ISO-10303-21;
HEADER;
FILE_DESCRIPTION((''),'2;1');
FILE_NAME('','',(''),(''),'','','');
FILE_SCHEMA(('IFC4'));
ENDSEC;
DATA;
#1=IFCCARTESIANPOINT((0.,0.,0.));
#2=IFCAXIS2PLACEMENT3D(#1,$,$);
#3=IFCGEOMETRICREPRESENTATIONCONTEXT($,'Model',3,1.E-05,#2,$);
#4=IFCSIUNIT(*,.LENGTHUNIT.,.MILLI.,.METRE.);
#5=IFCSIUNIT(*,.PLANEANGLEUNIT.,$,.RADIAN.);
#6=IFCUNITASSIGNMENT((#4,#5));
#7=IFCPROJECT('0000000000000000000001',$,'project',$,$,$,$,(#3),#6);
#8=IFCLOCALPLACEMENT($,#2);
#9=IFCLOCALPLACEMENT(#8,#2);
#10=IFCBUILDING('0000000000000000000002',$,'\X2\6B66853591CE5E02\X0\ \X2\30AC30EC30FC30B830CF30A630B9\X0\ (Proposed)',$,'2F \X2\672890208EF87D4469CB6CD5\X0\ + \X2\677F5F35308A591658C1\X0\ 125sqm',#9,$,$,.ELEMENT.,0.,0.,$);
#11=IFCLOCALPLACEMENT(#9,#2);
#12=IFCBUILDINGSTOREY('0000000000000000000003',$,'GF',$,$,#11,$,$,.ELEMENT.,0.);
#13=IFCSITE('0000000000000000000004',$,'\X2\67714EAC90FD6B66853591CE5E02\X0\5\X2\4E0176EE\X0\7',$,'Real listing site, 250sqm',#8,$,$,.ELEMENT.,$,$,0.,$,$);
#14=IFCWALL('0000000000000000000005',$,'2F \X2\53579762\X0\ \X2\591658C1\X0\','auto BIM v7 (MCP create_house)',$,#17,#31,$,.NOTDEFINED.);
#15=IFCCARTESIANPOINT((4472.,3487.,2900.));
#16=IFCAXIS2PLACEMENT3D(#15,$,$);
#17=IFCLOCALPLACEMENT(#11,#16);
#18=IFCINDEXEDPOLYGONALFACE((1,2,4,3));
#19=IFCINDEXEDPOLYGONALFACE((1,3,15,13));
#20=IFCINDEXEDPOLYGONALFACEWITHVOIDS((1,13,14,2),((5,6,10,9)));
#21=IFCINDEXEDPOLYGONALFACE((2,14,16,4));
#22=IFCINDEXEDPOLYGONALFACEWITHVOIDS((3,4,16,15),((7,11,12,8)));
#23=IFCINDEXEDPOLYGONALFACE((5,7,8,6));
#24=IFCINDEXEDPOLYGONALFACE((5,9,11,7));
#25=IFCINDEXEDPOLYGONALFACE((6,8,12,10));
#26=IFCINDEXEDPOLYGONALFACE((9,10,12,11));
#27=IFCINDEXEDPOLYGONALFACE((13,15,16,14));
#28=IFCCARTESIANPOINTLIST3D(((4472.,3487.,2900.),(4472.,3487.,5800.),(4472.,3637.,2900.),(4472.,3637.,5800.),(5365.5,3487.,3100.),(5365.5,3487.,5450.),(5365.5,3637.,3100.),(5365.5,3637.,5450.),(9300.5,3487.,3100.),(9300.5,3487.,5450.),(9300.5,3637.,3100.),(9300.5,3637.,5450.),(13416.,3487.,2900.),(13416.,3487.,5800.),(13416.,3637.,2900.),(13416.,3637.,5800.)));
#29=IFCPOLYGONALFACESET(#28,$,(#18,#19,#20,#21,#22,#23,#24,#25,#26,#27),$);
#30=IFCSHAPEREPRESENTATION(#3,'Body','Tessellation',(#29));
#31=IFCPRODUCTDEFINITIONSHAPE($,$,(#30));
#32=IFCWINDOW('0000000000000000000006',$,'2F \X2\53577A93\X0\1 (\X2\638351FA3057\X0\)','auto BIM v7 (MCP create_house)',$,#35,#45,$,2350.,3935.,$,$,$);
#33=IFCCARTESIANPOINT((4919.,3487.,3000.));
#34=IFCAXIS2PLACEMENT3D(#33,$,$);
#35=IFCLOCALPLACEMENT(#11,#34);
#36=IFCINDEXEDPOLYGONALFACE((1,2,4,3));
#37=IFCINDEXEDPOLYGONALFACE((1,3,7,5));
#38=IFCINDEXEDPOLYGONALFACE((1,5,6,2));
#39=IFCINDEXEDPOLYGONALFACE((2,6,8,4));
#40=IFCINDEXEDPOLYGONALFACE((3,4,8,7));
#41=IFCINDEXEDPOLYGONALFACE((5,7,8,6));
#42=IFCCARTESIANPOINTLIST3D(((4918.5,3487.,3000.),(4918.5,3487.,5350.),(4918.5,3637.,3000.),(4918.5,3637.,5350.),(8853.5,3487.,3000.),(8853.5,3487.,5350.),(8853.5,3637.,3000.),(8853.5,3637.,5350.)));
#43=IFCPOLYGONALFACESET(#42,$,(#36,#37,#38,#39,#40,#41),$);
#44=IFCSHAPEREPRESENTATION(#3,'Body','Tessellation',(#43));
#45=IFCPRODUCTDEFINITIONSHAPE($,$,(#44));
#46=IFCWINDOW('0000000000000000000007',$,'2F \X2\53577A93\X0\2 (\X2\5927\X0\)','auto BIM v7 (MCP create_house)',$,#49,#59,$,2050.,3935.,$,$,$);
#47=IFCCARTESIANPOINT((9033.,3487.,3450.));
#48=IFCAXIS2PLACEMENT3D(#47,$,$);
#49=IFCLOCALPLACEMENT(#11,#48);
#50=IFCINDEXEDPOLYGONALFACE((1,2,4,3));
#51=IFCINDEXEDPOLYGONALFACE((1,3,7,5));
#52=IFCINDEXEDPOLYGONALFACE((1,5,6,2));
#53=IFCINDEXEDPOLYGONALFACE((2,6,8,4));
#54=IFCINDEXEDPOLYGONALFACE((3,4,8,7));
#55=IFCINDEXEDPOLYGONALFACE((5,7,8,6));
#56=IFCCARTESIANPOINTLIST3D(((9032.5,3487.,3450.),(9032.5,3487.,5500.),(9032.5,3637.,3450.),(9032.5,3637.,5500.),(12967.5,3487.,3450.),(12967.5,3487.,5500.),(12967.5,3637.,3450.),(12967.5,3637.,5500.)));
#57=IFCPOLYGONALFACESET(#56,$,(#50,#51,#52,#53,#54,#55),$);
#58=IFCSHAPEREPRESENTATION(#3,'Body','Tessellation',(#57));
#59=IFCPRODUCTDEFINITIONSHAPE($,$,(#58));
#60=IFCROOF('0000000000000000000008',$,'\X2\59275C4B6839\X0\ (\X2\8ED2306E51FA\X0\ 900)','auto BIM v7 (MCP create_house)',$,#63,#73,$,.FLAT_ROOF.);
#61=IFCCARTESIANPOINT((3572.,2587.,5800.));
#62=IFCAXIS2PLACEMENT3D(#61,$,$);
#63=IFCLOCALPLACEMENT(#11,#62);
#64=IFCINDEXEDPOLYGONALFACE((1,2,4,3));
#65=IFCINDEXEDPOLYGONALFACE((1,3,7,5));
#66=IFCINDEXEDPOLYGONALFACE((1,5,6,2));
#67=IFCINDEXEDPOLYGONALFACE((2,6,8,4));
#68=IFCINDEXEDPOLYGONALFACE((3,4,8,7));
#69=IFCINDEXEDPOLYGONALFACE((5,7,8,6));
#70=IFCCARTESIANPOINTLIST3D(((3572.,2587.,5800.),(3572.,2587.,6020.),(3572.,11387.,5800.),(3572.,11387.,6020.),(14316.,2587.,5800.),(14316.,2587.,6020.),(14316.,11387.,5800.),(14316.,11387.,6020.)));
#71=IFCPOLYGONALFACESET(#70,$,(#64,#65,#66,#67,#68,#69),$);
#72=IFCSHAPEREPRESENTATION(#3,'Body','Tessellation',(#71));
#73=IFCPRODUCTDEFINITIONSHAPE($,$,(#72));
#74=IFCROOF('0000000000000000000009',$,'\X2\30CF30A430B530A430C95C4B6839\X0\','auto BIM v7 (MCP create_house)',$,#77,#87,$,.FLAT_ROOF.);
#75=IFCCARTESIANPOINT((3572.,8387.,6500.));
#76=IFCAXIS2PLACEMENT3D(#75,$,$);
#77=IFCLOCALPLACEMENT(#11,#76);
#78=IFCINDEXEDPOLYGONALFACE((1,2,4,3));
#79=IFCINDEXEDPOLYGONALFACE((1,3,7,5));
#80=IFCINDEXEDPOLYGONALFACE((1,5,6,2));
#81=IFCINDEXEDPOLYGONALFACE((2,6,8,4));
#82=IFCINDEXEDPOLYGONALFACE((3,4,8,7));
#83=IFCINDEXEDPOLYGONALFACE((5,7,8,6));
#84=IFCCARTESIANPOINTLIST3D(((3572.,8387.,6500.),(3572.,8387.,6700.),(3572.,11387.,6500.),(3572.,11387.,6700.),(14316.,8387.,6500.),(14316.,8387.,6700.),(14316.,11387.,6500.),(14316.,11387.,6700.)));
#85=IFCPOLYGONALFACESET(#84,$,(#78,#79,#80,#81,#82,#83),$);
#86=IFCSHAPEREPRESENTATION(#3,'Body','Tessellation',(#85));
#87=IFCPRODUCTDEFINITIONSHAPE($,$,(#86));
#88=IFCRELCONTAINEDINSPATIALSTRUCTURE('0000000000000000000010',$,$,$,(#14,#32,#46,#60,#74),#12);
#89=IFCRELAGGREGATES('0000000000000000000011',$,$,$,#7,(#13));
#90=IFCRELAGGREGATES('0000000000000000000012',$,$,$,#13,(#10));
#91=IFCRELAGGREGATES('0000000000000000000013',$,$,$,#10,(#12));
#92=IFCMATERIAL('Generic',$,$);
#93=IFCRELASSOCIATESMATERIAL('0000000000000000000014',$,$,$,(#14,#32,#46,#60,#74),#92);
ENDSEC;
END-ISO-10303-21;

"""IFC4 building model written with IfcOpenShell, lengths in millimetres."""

from ifc_helpers import new_model, si_unit, frame, frame_2d, origin, place, context, project, spatial, rectangle, extrude, material, element, fill, save


model = new_model("IFC4")

# Units and contexts
model_context = context("Model", 3, precision=1e-05, world=origin())
ifc_project = project(units=[si_unit("LENGTHUNIT", "METRE", prefix="MILLI"), si_unit("PLANEANGLEUNIT", "RADIAN")], contexts=[model_context])

# Site, building, storey
site_placement = place(None, origin())
site = spatial("IfcSite", under=ifc_project, at=site_placement, Name="東京都武蔵野市5丁目7", ObjectType="Real listing site, 250sqm", CompositionType="ELEMENT", RefElevation=0.0)
building_placement = place(site_placement, origin())
building = spatial("IfcBuilding", under=site, at=building_placement, Name="武蔵野市 ガレージハウス (Proposed)", ObjectType="2F 木造軸組構法 + 板張り外壁 125sqm", CompositionType="ELEMENT", ElevationOfRefHeight=0.0, ElevationOfTerrain=0.0)
storey_placement = place(building_placement, origin())
storey = spatial("IfcBuildingStorey", under=building, at=storey_placement, Name="GF", CompositionType="ELEMENT", Elevation=0.0)

# Shared definitions
ifc_material = material(Name="Generic")

# Wall, openings, windows
wall_1_placement = place(storey_placement, frame((4472.0, 3487.0, 2900.0)))
wall_1 = element("IfcWall", 1, at=wall_1_placement, inside=storey, material=ifc_material, Name="2F 南面 外壁", Description="auto BIM v7 (MCP create_house)", PredefinedType="NOTDEFINED", context=model_context, shape_type="SweptSolid", body=[
    extrude(rectangle(XDim=8944.0, YDim=150.0, at=frame_2d((4472.0, 75.0))), frame((4472.0, 3487.0, 2900.0)), (0.0, 0.0, 1.0), 2900.0),
])
opening_1_placement = place(storey_placement, frame((4919.0, 3487.0, 3000.0)))
opening_1 = element("IfcOpeningElement", 2, at=opening_1_placement, cuts=wall_1, PredefinedType="NOTDEFINED", context=model_context, shape_type="SweptSolid", body=[
    extrude(rectangle(XDim=3935.0, YDim=150.0, at=frame_2d((1967.0, 75.0))), frame((4919.0, 3487.0, 3000.0)), (0.0, 0.0, 1.0), 2350.0),
])
opening_2_placement = place(storey_placement, frame((9033.0, 3487.0, 3450.0)))
opening_2 = element("IfcOpeningElement", 3, at=opening_2_placement, cuts=wall_1, PredefinedType="NOTDEFINED", context=model_context, shape_type="SweptSolid", body=[
    extrude(rectangle(XDim=3935.0, YDim=150.0, at=frame_2d((1967.0, 75.0))), frame((9033.0, 3487.0, 3450.0)), (0.0, 0.0, 1.0), 2050.0),
])
window_1_placement = place(storey_placement, frame((4919.0, 3487.0, 3000.0)))
window_1 = element("IfcWindow", 4, at=window_1_placement, inside=storey, material=ifc_material, Name="2F 南窓1 (掃出し)", Description="auto BIM v7 (MCP create_house)", OverallHeight=2350.0, OverallWidth=3935.0, context=model_context, shape_type="SweptSolid", body=[
    extrude(rectangle(XDim=3935.0, YDim=150.0, at=frame_2d((1967.0, 75.0))), frame((4919.0, 3487.0, 3000.0)), (0.0, 0.0, 1.0), 2350.0),
])
fill(opening_1, window_1)
window_2_placement = place(storey_placement, frame((9033.0, 3487.0, 3450.0)))
window_2 = element("IfcWindow", 5, at=window_2_placement, inside=storey, material=ifc_material, Name="2F 南窓2 (大)", Description="auto BIM v7 (MCP create_house)", OverallHeight=2050.0, OverallWidth=3935.0, context=model_context, shape_type="SweptSolid", body=[
    extrude(rectangle(XDim=3935.0, YDim=150.0, at=frame_2d((1967.0, 75.0))), frame((9033.0, 3487.0, 3450.0)), (0.0, 0.0, 1.0), 2050.0),
])
fill(opening_2, window_2)

# Roofs
roof_1_placement = place(storey_placement, frame((3572.0, 2587.0, 5800.0)))
element("IfcRoof", 6, at=roof_1_placement, inside=storey, material=ifc_material, Name="大屋根 (軒の出 900)", Description="auto BIM v7 (MCP create_house)", PredefinedType="FLAT_ROOF", context=model_context, shape_type="SweptSolid", body=[
    extrude(rectangle(XDim=10744.0, YDim=8800.0, at=frame_2d((5372.0, 4400.0))), frame((3572.0, 2587.0, 5800.0)), (0.0, 0.0, 1.0), 220.0),
])
roof_2_placement = place(storey_placement, frame((3572.0, 8387.0, 6500.0)))
element("IfcRoof", 7, at=roof_2_placement, inside=storey, material=ifc_material, Name="ハイサイド屋根", Description="auto BIM v7 (MCP create_house)", PredefinedType="FLAT_ROOF", context=model_context, shape_type="SweptSolid", body=[
    extrude(rectangle(XDim=10744.0, YDim=3000.0, at=frame_2d((5372.0, 1500.0))), frame((3572.0, 8387.0, 6500.0)), (0.0, 0.0, 1.0), 200.0),
])

save(model, "model.ifc")
